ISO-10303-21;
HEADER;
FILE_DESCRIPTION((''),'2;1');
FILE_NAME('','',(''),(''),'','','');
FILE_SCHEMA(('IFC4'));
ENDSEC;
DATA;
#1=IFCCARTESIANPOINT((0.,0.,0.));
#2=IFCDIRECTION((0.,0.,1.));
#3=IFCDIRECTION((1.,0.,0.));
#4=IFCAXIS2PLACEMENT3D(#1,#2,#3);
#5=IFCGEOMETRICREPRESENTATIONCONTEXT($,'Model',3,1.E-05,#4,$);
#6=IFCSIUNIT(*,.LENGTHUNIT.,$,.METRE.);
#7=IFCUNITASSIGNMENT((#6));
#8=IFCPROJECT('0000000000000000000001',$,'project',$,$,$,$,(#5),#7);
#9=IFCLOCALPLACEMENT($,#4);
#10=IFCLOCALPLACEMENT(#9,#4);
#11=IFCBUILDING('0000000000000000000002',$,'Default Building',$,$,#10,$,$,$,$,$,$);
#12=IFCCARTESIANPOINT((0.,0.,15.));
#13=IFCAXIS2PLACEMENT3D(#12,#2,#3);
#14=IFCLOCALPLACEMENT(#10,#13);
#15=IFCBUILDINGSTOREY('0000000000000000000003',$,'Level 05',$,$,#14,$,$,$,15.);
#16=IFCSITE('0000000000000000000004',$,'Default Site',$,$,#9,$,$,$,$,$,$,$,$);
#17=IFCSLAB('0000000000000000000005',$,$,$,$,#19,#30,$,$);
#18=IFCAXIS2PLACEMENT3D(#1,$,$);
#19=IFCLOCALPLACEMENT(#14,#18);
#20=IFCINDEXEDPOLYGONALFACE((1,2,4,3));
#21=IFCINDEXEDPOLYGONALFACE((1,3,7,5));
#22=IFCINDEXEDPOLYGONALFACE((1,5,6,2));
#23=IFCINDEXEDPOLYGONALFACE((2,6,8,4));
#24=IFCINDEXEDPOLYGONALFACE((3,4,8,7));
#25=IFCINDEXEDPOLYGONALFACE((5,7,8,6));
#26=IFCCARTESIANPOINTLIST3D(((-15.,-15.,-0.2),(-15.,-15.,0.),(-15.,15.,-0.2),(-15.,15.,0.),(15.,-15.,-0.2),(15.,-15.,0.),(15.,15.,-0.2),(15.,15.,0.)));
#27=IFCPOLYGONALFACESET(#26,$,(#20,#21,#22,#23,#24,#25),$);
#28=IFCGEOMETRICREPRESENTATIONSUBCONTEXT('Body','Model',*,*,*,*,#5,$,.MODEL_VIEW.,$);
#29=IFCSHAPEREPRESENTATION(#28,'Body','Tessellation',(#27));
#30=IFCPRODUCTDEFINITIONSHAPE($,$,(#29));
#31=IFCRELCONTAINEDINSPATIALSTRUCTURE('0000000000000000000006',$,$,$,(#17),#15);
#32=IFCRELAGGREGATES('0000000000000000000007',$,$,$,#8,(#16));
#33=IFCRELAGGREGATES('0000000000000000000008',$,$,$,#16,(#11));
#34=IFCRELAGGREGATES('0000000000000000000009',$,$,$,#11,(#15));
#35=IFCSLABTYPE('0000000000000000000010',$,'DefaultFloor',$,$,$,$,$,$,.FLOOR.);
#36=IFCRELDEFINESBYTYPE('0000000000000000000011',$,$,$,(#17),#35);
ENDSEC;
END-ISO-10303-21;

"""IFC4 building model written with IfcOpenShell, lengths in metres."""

from ifc_helpers import new_model, si_unit, frame, origin_with_axes, place, context, subcontext, project, spatial, polyline, outline, extrude, type_object, element, save


model = new_model("IFC4")

# Units and contexts
model_context = context("Model", 3, precision=1e-05, world=origin_with_axes())
body_context = subcontext(model_context, "Body", "Model", "MODEL_VIEW")
ifc_project = project(units=[si_unit("LENGTHUNIT", "METRE")], contexts=[model_context])

# Site, building, storey
site_placement = place(None, origin_with_axes())
site = spatial("IfcSite", under=ifc_project, at=site_placement, Name="Default Site")
building_placement = place(site_placement, origin_with_axes())
building = spatial("IfcBuilding", under=site, at=building_placement, Name="Default Building")
storey_placement = place(building_placement, frame((0.0, 0.0, 15.0), z_axis=(0.0, 0.0, 1.0), x_axis=(1.0, 0.0, 0.0)))
storey = spatial("IfcBuildingStorey", under=building, at=storey_placement, Name="Level 05", Elevation=15.0)

# Slab
slab_type = type_object("IfcSlabType", Name="DefaultFloor", PredefinedType="FLOOR")
slab_placement = place(storey_placement, frame((0.0, 0.0, -15.0), z_axis=(0.0, 0.0, 1.0), x_axis=(1.0, 0.0, 0.0)))
element("IfcSlab", 1, at=slab_placement, inside=storey, type_object=slab_type, context=body_context, shape_type="SweptSolid", body=[
    extrude(outline(polyline([(-15.0, 15.0), (15.0, 15.0), (15.0, -15.0), (-15.0, -15.0), (-15.0, 15.0)])), frame((0.0, 0.0, 15.0), z_axis=(0.0, 0.0, 1.0), x_axis=(1.0, 0.0, 0.0)), (0.0, 0.0, -1.0), 0.2),
])

save(model, "model.ifc")
